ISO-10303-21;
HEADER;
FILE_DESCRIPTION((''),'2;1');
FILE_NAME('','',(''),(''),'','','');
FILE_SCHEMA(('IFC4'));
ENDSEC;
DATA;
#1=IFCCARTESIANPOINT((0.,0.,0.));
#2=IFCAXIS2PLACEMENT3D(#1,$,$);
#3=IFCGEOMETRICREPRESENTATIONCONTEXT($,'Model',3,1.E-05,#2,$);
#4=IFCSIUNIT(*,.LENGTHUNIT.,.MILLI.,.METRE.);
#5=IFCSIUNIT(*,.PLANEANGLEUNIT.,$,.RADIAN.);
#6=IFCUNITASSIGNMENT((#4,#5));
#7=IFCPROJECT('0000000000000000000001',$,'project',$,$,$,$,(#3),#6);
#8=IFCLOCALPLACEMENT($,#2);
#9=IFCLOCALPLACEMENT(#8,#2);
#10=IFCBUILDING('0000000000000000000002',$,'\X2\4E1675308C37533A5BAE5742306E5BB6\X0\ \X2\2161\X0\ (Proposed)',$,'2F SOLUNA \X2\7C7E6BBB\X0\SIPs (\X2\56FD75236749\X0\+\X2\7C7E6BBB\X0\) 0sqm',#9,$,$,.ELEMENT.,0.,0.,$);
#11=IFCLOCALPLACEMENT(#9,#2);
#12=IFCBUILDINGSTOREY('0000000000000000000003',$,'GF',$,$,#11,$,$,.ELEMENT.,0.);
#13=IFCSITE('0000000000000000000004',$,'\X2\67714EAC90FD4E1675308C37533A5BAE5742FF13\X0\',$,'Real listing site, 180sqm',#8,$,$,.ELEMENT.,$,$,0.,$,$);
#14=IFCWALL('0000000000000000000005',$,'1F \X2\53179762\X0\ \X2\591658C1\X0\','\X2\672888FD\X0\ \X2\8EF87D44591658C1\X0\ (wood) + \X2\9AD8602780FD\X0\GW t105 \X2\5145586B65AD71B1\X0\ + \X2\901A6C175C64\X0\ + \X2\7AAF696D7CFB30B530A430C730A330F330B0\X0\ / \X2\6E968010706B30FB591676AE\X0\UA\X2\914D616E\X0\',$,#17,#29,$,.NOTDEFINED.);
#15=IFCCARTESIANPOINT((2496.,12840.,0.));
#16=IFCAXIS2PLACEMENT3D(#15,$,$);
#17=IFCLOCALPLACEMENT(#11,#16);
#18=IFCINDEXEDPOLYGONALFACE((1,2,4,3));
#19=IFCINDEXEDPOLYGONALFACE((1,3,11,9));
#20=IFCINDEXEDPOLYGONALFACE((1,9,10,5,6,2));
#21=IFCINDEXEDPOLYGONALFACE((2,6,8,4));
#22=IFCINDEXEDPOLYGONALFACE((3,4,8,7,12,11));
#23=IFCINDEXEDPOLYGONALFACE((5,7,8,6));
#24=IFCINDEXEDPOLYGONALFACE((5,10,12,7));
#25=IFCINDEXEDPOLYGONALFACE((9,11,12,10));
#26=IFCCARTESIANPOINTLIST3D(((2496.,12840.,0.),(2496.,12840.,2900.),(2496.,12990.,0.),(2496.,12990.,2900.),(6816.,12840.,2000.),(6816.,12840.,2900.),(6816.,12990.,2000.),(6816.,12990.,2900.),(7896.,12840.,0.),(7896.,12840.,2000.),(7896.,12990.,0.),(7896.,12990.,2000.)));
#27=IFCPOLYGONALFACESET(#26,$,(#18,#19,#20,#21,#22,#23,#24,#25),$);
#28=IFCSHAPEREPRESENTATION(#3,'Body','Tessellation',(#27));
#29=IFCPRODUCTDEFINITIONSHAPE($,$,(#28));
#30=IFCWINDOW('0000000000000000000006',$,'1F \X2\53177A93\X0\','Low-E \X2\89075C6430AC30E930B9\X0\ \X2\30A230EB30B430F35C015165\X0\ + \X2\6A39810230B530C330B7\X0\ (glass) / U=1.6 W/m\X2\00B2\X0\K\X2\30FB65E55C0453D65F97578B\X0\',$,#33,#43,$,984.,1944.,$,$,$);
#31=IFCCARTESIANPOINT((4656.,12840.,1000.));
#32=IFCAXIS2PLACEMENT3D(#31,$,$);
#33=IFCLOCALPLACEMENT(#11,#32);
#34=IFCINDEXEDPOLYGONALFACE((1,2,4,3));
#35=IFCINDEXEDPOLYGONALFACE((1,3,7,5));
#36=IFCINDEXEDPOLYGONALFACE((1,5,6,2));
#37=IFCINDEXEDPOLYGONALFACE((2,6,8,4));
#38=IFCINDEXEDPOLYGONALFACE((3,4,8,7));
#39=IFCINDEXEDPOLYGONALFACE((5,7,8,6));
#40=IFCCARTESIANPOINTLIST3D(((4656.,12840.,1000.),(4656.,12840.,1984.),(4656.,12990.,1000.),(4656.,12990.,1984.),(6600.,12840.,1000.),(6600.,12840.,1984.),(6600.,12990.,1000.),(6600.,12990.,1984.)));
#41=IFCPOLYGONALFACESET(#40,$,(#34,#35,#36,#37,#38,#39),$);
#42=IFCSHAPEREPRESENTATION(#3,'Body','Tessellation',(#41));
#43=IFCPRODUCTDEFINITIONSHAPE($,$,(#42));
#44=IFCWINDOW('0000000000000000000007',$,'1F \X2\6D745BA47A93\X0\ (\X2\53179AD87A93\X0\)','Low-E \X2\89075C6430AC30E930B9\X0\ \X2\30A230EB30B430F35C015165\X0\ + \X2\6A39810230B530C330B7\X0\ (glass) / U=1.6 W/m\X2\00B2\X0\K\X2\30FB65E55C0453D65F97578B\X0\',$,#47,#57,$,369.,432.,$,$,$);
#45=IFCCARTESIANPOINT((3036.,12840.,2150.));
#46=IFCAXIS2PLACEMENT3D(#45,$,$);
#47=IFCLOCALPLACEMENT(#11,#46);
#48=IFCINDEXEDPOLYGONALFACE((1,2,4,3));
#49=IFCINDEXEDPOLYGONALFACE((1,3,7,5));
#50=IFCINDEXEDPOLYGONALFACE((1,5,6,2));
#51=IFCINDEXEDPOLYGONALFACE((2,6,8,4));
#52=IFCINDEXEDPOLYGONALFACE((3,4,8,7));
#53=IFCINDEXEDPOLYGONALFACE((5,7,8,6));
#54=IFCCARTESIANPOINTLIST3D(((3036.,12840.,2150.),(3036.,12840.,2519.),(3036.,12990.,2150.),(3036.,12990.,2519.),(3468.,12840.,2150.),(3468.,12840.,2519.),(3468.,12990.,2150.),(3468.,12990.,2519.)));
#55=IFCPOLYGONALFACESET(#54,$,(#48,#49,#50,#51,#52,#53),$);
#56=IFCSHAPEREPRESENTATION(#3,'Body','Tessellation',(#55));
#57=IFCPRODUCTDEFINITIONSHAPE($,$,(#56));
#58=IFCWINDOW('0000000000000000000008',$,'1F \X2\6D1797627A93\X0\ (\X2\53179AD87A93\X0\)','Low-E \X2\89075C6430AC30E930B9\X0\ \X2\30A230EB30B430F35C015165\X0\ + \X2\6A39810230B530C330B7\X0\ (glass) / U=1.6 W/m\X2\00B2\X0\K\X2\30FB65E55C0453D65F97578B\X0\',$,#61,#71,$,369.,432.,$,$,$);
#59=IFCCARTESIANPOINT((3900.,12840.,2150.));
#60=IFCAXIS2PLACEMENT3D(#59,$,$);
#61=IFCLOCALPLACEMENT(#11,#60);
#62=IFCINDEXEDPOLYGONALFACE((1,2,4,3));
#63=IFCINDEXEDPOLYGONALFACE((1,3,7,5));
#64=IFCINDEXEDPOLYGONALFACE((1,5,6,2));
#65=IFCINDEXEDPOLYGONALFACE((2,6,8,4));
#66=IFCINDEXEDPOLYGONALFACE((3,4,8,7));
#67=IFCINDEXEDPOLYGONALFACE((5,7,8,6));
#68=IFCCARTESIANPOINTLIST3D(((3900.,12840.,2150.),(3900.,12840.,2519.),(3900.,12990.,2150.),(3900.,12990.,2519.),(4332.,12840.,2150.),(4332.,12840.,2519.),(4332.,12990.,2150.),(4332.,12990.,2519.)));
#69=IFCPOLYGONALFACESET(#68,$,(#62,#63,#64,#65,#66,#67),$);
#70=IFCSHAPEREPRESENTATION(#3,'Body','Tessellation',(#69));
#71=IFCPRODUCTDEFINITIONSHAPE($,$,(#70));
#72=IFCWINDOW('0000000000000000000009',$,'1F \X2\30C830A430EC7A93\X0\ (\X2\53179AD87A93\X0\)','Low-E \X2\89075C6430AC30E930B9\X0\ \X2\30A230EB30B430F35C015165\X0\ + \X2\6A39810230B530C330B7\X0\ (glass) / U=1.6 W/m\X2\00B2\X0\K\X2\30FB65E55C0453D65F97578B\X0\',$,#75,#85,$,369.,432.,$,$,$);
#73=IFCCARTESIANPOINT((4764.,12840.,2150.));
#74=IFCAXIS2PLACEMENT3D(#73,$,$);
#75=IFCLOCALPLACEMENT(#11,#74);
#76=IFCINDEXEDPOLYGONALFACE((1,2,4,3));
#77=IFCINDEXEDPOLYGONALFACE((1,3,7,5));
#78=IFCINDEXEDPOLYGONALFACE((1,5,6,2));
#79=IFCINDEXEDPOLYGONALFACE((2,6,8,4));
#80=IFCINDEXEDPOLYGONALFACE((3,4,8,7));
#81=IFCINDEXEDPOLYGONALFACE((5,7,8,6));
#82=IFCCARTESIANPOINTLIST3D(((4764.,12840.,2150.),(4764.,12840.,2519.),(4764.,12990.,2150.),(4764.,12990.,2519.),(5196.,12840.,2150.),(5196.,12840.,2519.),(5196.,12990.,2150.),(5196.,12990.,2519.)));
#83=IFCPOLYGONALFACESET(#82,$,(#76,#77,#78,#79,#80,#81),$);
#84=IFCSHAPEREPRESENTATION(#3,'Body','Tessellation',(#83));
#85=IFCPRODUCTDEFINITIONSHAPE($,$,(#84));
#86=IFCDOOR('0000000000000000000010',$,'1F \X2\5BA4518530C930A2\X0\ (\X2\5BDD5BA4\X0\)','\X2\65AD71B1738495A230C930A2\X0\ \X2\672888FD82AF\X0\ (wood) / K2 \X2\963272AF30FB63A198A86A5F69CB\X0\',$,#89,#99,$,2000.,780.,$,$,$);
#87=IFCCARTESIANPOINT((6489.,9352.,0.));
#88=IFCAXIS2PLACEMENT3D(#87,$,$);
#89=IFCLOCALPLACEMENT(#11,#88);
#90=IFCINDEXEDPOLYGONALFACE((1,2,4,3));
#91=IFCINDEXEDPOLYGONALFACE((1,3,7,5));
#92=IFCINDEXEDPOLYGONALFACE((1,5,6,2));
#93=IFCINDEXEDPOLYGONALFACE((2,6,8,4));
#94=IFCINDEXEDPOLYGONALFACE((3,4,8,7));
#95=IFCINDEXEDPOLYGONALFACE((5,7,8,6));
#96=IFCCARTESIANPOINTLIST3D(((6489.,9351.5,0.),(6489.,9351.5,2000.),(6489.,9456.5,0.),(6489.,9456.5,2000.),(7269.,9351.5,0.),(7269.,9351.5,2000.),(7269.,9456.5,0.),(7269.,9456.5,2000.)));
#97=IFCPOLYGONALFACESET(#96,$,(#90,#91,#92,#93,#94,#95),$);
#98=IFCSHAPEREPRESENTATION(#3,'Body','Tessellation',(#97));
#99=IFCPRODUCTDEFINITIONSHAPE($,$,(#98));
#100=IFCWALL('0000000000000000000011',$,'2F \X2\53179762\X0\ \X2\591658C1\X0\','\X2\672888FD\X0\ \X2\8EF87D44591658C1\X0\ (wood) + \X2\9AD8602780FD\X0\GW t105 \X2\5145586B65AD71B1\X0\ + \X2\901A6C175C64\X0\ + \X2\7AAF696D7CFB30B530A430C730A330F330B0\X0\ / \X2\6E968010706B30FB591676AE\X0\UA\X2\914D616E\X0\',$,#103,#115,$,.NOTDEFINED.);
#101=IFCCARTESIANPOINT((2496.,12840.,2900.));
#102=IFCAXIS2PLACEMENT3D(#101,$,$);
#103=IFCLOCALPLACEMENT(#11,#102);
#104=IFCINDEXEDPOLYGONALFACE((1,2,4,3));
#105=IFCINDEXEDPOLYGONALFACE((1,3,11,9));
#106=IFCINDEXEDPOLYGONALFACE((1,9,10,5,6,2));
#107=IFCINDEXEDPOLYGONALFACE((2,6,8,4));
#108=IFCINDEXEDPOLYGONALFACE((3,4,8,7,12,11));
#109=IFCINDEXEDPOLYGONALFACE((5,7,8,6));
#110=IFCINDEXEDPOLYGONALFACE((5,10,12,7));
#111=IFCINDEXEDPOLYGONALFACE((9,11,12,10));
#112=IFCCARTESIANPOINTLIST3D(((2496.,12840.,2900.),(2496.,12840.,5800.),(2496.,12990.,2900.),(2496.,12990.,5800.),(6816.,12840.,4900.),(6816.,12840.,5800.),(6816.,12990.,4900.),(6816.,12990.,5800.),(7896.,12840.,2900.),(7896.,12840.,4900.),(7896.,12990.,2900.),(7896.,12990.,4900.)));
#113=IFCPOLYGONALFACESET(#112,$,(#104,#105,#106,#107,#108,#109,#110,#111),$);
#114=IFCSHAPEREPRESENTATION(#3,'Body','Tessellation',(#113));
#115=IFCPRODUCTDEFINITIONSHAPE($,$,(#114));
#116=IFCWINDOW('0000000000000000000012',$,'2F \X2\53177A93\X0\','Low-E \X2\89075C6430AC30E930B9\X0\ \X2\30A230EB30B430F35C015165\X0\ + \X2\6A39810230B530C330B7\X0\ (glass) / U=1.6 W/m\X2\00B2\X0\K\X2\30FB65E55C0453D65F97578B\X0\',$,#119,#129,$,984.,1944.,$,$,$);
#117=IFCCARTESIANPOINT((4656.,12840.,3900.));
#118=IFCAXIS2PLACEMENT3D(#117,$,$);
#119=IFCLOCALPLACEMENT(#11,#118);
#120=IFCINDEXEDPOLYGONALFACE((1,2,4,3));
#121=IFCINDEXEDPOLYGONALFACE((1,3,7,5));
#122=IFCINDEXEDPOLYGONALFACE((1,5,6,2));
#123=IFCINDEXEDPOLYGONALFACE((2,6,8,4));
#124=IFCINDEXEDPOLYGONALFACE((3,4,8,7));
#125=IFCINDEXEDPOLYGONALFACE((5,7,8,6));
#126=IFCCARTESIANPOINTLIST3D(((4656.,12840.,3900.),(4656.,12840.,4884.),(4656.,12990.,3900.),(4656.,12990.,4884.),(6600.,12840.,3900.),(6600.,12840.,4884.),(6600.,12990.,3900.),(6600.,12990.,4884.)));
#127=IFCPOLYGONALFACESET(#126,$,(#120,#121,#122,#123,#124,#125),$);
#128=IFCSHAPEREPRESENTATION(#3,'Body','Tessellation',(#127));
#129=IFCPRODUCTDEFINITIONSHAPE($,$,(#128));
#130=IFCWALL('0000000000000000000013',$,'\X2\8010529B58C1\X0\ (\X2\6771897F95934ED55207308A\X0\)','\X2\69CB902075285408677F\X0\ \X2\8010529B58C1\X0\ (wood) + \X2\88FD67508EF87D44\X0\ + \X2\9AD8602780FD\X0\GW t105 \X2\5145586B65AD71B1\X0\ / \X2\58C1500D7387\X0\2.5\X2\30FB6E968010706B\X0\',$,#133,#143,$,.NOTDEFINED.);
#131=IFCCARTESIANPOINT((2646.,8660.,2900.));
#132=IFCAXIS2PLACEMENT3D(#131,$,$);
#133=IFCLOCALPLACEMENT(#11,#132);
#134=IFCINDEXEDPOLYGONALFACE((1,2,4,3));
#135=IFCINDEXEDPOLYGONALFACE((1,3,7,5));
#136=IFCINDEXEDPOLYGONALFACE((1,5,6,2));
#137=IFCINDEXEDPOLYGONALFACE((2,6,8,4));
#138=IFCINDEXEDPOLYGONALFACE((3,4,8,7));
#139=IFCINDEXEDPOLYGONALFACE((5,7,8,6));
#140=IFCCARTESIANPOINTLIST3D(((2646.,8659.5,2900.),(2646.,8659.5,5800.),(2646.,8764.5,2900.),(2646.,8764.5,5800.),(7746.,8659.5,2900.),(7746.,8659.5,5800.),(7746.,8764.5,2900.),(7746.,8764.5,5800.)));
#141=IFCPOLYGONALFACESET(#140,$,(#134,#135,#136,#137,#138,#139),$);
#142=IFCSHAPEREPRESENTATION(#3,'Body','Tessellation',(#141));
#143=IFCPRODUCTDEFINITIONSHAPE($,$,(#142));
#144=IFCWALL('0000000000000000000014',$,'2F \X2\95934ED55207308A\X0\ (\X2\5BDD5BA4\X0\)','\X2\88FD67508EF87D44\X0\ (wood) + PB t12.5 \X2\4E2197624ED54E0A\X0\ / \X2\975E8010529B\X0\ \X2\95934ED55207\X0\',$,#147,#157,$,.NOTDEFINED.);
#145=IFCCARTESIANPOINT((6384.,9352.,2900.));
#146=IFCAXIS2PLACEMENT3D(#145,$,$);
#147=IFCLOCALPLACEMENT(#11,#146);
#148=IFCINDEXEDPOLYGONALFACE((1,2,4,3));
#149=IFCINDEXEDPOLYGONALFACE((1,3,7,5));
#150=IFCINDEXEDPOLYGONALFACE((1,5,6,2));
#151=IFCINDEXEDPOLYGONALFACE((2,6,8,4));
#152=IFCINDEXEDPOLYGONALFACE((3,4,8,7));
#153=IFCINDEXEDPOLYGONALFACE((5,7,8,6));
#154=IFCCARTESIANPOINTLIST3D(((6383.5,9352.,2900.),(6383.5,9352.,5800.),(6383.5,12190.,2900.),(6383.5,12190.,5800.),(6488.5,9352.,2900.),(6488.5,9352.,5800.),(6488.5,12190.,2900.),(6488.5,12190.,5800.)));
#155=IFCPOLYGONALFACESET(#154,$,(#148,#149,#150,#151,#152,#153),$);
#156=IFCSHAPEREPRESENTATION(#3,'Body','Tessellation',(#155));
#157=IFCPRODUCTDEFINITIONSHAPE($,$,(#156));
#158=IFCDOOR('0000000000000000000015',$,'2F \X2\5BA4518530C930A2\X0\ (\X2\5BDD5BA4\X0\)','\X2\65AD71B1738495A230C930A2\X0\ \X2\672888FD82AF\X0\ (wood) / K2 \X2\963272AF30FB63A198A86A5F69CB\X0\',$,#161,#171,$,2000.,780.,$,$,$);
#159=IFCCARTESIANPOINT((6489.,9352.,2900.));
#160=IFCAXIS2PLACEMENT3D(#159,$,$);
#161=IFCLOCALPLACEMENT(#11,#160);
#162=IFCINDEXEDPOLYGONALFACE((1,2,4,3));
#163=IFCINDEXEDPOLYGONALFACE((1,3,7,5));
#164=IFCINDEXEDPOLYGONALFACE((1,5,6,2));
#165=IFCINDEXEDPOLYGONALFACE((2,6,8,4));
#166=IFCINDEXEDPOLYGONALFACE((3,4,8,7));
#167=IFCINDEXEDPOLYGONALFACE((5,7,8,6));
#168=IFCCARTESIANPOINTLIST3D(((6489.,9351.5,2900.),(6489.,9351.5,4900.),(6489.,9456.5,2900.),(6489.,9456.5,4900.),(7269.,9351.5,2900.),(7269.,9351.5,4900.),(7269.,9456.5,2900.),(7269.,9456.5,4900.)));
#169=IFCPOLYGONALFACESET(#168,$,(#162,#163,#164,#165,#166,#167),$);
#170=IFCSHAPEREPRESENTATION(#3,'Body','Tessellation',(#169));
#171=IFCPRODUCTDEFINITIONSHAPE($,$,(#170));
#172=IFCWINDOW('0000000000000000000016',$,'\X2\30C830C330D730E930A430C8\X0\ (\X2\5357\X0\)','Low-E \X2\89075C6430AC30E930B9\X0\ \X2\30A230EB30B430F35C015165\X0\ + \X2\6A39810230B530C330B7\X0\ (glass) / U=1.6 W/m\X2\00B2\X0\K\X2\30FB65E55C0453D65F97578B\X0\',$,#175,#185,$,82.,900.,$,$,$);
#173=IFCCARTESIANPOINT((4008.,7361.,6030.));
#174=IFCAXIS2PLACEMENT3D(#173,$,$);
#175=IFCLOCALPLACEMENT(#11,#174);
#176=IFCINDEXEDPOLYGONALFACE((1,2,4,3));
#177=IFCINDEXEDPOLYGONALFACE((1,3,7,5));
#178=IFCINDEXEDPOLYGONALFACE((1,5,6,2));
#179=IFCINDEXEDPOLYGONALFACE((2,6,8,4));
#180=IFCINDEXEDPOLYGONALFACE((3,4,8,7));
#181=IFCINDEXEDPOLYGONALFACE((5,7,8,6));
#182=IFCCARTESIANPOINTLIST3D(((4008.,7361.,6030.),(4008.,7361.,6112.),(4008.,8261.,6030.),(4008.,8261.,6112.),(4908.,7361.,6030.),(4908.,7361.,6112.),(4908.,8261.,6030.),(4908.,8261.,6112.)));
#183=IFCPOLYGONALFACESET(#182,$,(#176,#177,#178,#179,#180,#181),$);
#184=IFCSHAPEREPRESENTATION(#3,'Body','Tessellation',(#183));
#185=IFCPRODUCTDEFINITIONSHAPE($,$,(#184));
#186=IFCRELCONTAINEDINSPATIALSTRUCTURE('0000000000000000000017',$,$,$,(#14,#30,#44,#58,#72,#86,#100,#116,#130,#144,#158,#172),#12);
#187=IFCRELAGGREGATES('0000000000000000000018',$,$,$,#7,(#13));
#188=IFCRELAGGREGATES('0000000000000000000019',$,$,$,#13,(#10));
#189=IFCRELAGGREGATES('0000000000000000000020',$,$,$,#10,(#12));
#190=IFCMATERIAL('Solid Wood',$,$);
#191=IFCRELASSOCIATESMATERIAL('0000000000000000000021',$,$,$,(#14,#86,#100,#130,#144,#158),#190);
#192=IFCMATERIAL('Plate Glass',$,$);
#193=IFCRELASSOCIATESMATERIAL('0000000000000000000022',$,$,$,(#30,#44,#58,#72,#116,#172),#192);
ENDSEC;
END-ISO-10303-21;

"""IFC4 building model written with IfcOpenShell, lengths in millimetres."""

from ifc_helpers import new_model, si_unit, frame, frame_2d, origin, place, context, project, spatial, rectangle, extrude, material, element, fill, save


model = new_model("IFC4")

# Units and contexts
model_context = context("Model", 3, precision=1e-05, world=origin())
ifc_project = project(units=[si_unit("LENGTHUNIT", "METRE", prefix="MILLI"), si_unit("PLANEANGLEUNIT", "RADIAN")], contexts=[model_context])

# Site, building, storey
site_placement = place(None, origin())
site = spatial("IfcSite", under=ifc_project, at=site_placement, Name="東京都世田谷区宮坂３", ObjectType="Real listing site, 180sqm", CompositionType="ELEMENT", RefElevation=0.0)
building_placement = place(site_placement, origin())
building = spatial("IfcBuilding", under=site, at=building_placement, Name="世田谷区宮坂の家 Ⅱ (Proposed)", ObjectType="2F SOLUNA 籾殻SIPs (国産杉+籾殻) 0sqm", CompositionType="ELEMENT", ElevationOfRefHeight=0.0, ElevationOfTerrain=0.0)
storey_placement = place(building_placement, origin())
storey = spatial("IfcBuildingStorey", under=building, at=storey_placement, Name="GF", CompositionType="ELEMENT", Elevation=0.0)

# Wall, openings, windows
ifc_material_1 = material(Name="Solid Wood")
wall_1_placement = place(storey_placement, frame((2496.0, 12840.0, 0.0)))
wall_1 = element("IfcWall", 1, at=wall_1_placement, inside=storey, material=ifc_material_1, Name="1F 北面 外壁", Description="木製 軸組外壁 (wood) + 高性能GW t105 充填断熱 + 通気層 + 窯業系サイディング / 準耐火・外皮UA配慮", PredefinedType="NOTDEFINED", context=model_context, shape_type="SweptSolid", body=[
    extrude(rectangle(XDim=5400.0, YDim=150.0, at=frame_2d((2700.0, 75.0))), frame((2496.0, 12840.0, 0.0)), (0.0, 0.0, 1.0), 2900.0),
])
opening_1_placement = place(storey_placement, frame((4656.0, 12840.0, 1000.0)))
opening_1 = element("IfcOpeningElement", 2, at=opening_1_placement, cuts=wall_1, PredefinedType="NOTDEFINED", context=model_context, shape_type="SweptSolid", body=[
    extrude(rectangle(XDim=1944.0, YDim=150.0, at=frame_2d((972.0, 75.0))), frame((4656.0, 12840.0, 1000.0)), (0.0, 0.0, 1.0), 984.0),
])
opening_2_placement = place(storey_placement, frame((3036.0, 12840.0, 2150.0)))
opening_2 = element("IfcOpeningElement", 3, at=opening_2_placement, cuts=wall_1, PredefinedType="NOTDEFINED", context=model_context, shape_type="SweptSolid", body=[
    extrude(rectangle(XDim=432.0, YDim=150.0, at=frame_2d((216.0, 75.0))), frame((3036.0, 12840.0, 2150.0)), (0.0, 0.0, 1.0), 369.0),
])
opening_3_placement = place(storey_placement, frame((3900.0, 12840.0, 2150.0)))
opening_3 = element("IfcOpeningElement", 4, at=opening_3_placement, cuts=wall_1, PredefinedType="NOTDEFINED", context=model_context, shape_type="SweptSolid", body=[
    extrude(rectangle(XDim=432.0, YDim=150.0, at=frame_2d((216.0, 75.0))), frame((3900.0, 12840.0, 2150.0)), (0.0, 0.0, 1.0), 369.0),
])
opening_4_placement = place(storey_placement, frame((4764.0, 12840.0, 2150.0)))
opening_4 = element("IfcOpeningElement", 5, at=opening_4_placement, cuts=wall_1, PredefinedType="NOTDEFINED", context=model_context, shape_type="SweptSolid", body=[
    extrude(rectangle(XDim=432.0, YDim=150.0, at=frame_2d((216.0, 75.0))), frame((4764.0, 12840.0, 2150.0)), (0.0, 0.0, 1.0), 369.0),
])
ifc_material_2 = material(Name="Plate Glass")
window_1_placement = place(storey_placement, frame((4656.0, 12840.0, 1000.0)))
window_1 = element("IfcWindow", 6, at=window_1_placement, inside=storey, material=ifc_material_2, Name="1F 北窓", Description="Low-E 複層ガラス アルゴン封入 + 樹脂サッシ (glass) / U=1.6 W/m²K・日射取得型", OverallHeight=984.0, OverallWidth=1944.0, context=model_context, shape_type="SweptSolid", body=[
    extrude(rectangle(XDim=1944.0, YDim=150.0, at=frame_2d((972.0, 75.0))), frame((4656.0, 12840.0, 1000.0)), (0.0, 0.0, 1.0), 984.0),
])
fill(opening_1, window_1)
window_2_placement = place(storey_placement, frame((3036.0, 12840.0, 2150.0)))
window_2 = element("IfcWindow", 7, at=window_2_placement, inside=storey, material=ifc_material_2, Name="1F 浴室窓 (北高窓)", Description="Low-E 複層ガラス アルゴン封入 + 樹脂サッシ (glass) / U=1.6 W/m²K・日射取得型", OverallHeight=369.0, OverallWidth=432.0, context=model_context, shape_type="SweptSolid", body=[
    extrude(rectangle(XDim=432.0, YDim=150.0, at=frame_2d((216.0, 75.0))), frame((3036.0, 12840.0, 2150.0)), (0.0, 0.0, 1.0), 369.0),
])
fill(opening_2, window_2)
window_3_placement = place(storey_placement, frame((3900.0, 12840.0, 2150.0)))
window_3 = element("IfcWindow", 8, at=window_3_placement, inside=storey, material=ifc_material_2, Name="1F 洗面窓 (北高窓)", Description="Low-E 複層ガラス アルゴン封入 + 樹脂サッシ (glass) / U=1.6 W/m²K・日射取得型", OverallHeight=369.0, OverallWidth=432.0, context=model_context, shape_type="SweptSolid", body=[
    extrude(rectangle(XDim=432.0, YDim=150.0, at=frame_2d((216.0, 75.0))), frame((3900.0, 12840.0, 2150.0)), (0.0, 0.0, 1.0), 369.0),
])
fill(opening_3, window_3)
window_4_placement = place(storey_placement, frame((4764.0, 12840.0, 2150.0)))
window_4 = element("IfcWindow", 9, at=window_4_placement, inside=storey, material=ifc_material_2, Name="1F トイレ窓 (北高窓)", Description="Low-E 複層ガラス アルゴン封入 + 樹脂サッシ (glass) / U=1.6 W/m²K・日射取得型", OverallHeight=369.0, OverallWidth=432.0, context=model_context, shape_type="SweptSolid", body=[
    extrude(rectangle(XDim=432.0, YDim=150.0, at=frame_2d((216.0, 75.0))), frame((4764.0, 12840.0, 2150.0)), (0.0, 0.0, 1.0), 369.0),
])
fill(opening_4, window_4)

# Door
door_1_placement = place(storey_placement, frame((6489.0, 9352.0, 0.0)))
element("IfcDoor", 10, at=door_1_placement, inside=storey, material=ifc_material_1, Name="1F 室内ドア (寝室)", Description="断熱玄関ドア 木製芯 (wood) / K2 防犯・採風機構", OverallHeight=2000.0, OverallWidth=780.0, context=model_context, shape_type="SweptSolid", body=[
    extrude(rectangle(XDim=780.0, YDim=105.0, at=frame_2d((390.0, 52.0))), frame((6489.0, 9352.0, 0.0)), (0.0, 0.0, 1.0), 2000.0),
])

# Wall, opening, window
wall_2_placement = place(storey_placement, frame((2496.0, 12840.0, 2900.0)))
wall_2 = element("IfcWall", 11, at=wall_2_placement, inside=storey, material=ifc_material_1, Name="2F 北面 外壁", Description="木製 軸組外壁 (wood) + 高性能GW t105 充填断熱 + 通気層 + 窯業系サイディング / 準耐火・外皮UA配慮", PredefinedType="NOTDEFINED", context=model_context, shape_type="SweptSolid", body=[
    extrude(rectangle(XDim=5400.0, YDim=150.0, at=frame_2d((2700.0, 75.0))), frame((2496.0, 12840.0, 2900.0)), (0.0, 0.0, 1.0), 2900.0),
])
opening_5_placement = place(storey_placement, frame((4656.0, 12840.0, 3900.0)))
opening_5 = element("IfcOpeningElement", 12, at=opening_5_placement, cuts=wall_2, PredefinedType="NOTDEFINED", context=model_context, shape_type="SweptSolid", body=[
    extrude(rectangle(XDim=1944.0, YDim=150.0, at=frame_2d((972.0, 75.0))), frame((4656.0, 12840.0, 3900.0)), (0.0, 0.0, 1.0), 984.0),
])
window_5_placement = place(storey_placement, frame((4656.0, 12840.0, 3900.0)))
window_5 = element("IfcWindow", 13, at=window_5_placement, inside=storey, material=ifc_material_2, Name="2F 北窓", Description="Low-E 複層ガラス アルゴン封入 + 樹脂サッシ (glass) / U=1.6 W/m²K・日射取得型", OverallHeight=984.0, OverallWidth=1944.0, context=model_context, shape_type="SweptSolid", body=[
    extrude(rectangle(XDim=1944.0, YDim=150.0, at=frame_2d((972.0, 75.0))), frame((4656.0, 12840.0, 3900.0)), (0.0, 0.0, 1.0), 984.0),
])
fill(opening_5, window_5)

# Walls
wall_3_placement = place(storey_placement, frame((2646.0, 8660.0, 2900.0)))
element("IfcWall", 14, at=wall_3_placement, inside=storey, material=ifc_material_1, Name="耐力壁 (東西間仕切り)", Description="構造用合板 耐力壁 (wood) + 製材軸組 + 高性能GW t105 充填断熱 / 壁倍率2.5・準耐火", PredefinedType="NOTDEFINED", context=model_context, shape_type="SweptSolid", body=[
    extrude(rectangle(XDim=5100.0, YDim=105.0, at=frame_2d((2550.0, 52.0))), frame((2646.0, 8660.0, 2900.0)), (0.0, 0.0, 1.0), 2900.0),
])
wall_4_placement = place(storey_placement, frame((6384.0, 9352.0, 2900.0)))
element("IfcWall", 15, at=wall_4_placement, inside=storey, material=ifc_material_1, Name="2F 間仕切り (寝室)", Description="製材軸組 (wood) + PB t12.5 両面仕上 / 非耐力 間仕切", PredefinedType="NOTDEFINED", context=model_context, shape_type="SweptSolid", body=[
    extrude(rectangle(XDim=105.0, YDim=2838.0, at=frame_2d((52.0, 1419.0))), frame((6384.0, 9352.0, 2900.0)), (0.0, 0.0, 1.0), 2900.0),
])

# Door
door_2_placement = place(storey_placement, frame((6489.0, 9352.0, 2900.0)))
element("IfcDoor", 16, at=door_2_placement, inside=storey, material=ifc_material_1, Name="2F 室内ドア (寝室)", Description="断熱玄関ドア 木製芯 (wood) / K2 防犯・採風機構", OverallHeight=2000.0, OverallWidth=780.0, context=model_context, shape_type="SweptSolid", body=[
    extrude(rectangle(XDim=780.0, YDim=105.0, at=frame_2d((390.0, 52.0))), frame((6489.0, 9352.0, 2900.0)), (0.0, 0.0, 1.0), 2000.0),
])

# Window
window_6_placement = place(storey_placement, frame((4008.0, 7361.0, 6030.0)))
element("IfcWindow", 17, at=window_6_placement, inside=storey, material=ifc_material_2, Name="トップライト (南)", Description="Low-E 複層ガラス アルゴン封入 + 樹脂サッシ (glass) / U=1.6 W/m²K・日射取得型", OverallHeight=82.0, OverallWidth=900.0, context=model_context, shape_type="SweptSolid", body=[
    extrude(rectangle(XDim=900.0, YDim=900.0, at=frame_2d((450.0, 450.0))), frame((4008.0, 7361.0, 6030.0)), (0.0, 0.0, 1.0), 82.0),
])

save(model, "model.ifc")
